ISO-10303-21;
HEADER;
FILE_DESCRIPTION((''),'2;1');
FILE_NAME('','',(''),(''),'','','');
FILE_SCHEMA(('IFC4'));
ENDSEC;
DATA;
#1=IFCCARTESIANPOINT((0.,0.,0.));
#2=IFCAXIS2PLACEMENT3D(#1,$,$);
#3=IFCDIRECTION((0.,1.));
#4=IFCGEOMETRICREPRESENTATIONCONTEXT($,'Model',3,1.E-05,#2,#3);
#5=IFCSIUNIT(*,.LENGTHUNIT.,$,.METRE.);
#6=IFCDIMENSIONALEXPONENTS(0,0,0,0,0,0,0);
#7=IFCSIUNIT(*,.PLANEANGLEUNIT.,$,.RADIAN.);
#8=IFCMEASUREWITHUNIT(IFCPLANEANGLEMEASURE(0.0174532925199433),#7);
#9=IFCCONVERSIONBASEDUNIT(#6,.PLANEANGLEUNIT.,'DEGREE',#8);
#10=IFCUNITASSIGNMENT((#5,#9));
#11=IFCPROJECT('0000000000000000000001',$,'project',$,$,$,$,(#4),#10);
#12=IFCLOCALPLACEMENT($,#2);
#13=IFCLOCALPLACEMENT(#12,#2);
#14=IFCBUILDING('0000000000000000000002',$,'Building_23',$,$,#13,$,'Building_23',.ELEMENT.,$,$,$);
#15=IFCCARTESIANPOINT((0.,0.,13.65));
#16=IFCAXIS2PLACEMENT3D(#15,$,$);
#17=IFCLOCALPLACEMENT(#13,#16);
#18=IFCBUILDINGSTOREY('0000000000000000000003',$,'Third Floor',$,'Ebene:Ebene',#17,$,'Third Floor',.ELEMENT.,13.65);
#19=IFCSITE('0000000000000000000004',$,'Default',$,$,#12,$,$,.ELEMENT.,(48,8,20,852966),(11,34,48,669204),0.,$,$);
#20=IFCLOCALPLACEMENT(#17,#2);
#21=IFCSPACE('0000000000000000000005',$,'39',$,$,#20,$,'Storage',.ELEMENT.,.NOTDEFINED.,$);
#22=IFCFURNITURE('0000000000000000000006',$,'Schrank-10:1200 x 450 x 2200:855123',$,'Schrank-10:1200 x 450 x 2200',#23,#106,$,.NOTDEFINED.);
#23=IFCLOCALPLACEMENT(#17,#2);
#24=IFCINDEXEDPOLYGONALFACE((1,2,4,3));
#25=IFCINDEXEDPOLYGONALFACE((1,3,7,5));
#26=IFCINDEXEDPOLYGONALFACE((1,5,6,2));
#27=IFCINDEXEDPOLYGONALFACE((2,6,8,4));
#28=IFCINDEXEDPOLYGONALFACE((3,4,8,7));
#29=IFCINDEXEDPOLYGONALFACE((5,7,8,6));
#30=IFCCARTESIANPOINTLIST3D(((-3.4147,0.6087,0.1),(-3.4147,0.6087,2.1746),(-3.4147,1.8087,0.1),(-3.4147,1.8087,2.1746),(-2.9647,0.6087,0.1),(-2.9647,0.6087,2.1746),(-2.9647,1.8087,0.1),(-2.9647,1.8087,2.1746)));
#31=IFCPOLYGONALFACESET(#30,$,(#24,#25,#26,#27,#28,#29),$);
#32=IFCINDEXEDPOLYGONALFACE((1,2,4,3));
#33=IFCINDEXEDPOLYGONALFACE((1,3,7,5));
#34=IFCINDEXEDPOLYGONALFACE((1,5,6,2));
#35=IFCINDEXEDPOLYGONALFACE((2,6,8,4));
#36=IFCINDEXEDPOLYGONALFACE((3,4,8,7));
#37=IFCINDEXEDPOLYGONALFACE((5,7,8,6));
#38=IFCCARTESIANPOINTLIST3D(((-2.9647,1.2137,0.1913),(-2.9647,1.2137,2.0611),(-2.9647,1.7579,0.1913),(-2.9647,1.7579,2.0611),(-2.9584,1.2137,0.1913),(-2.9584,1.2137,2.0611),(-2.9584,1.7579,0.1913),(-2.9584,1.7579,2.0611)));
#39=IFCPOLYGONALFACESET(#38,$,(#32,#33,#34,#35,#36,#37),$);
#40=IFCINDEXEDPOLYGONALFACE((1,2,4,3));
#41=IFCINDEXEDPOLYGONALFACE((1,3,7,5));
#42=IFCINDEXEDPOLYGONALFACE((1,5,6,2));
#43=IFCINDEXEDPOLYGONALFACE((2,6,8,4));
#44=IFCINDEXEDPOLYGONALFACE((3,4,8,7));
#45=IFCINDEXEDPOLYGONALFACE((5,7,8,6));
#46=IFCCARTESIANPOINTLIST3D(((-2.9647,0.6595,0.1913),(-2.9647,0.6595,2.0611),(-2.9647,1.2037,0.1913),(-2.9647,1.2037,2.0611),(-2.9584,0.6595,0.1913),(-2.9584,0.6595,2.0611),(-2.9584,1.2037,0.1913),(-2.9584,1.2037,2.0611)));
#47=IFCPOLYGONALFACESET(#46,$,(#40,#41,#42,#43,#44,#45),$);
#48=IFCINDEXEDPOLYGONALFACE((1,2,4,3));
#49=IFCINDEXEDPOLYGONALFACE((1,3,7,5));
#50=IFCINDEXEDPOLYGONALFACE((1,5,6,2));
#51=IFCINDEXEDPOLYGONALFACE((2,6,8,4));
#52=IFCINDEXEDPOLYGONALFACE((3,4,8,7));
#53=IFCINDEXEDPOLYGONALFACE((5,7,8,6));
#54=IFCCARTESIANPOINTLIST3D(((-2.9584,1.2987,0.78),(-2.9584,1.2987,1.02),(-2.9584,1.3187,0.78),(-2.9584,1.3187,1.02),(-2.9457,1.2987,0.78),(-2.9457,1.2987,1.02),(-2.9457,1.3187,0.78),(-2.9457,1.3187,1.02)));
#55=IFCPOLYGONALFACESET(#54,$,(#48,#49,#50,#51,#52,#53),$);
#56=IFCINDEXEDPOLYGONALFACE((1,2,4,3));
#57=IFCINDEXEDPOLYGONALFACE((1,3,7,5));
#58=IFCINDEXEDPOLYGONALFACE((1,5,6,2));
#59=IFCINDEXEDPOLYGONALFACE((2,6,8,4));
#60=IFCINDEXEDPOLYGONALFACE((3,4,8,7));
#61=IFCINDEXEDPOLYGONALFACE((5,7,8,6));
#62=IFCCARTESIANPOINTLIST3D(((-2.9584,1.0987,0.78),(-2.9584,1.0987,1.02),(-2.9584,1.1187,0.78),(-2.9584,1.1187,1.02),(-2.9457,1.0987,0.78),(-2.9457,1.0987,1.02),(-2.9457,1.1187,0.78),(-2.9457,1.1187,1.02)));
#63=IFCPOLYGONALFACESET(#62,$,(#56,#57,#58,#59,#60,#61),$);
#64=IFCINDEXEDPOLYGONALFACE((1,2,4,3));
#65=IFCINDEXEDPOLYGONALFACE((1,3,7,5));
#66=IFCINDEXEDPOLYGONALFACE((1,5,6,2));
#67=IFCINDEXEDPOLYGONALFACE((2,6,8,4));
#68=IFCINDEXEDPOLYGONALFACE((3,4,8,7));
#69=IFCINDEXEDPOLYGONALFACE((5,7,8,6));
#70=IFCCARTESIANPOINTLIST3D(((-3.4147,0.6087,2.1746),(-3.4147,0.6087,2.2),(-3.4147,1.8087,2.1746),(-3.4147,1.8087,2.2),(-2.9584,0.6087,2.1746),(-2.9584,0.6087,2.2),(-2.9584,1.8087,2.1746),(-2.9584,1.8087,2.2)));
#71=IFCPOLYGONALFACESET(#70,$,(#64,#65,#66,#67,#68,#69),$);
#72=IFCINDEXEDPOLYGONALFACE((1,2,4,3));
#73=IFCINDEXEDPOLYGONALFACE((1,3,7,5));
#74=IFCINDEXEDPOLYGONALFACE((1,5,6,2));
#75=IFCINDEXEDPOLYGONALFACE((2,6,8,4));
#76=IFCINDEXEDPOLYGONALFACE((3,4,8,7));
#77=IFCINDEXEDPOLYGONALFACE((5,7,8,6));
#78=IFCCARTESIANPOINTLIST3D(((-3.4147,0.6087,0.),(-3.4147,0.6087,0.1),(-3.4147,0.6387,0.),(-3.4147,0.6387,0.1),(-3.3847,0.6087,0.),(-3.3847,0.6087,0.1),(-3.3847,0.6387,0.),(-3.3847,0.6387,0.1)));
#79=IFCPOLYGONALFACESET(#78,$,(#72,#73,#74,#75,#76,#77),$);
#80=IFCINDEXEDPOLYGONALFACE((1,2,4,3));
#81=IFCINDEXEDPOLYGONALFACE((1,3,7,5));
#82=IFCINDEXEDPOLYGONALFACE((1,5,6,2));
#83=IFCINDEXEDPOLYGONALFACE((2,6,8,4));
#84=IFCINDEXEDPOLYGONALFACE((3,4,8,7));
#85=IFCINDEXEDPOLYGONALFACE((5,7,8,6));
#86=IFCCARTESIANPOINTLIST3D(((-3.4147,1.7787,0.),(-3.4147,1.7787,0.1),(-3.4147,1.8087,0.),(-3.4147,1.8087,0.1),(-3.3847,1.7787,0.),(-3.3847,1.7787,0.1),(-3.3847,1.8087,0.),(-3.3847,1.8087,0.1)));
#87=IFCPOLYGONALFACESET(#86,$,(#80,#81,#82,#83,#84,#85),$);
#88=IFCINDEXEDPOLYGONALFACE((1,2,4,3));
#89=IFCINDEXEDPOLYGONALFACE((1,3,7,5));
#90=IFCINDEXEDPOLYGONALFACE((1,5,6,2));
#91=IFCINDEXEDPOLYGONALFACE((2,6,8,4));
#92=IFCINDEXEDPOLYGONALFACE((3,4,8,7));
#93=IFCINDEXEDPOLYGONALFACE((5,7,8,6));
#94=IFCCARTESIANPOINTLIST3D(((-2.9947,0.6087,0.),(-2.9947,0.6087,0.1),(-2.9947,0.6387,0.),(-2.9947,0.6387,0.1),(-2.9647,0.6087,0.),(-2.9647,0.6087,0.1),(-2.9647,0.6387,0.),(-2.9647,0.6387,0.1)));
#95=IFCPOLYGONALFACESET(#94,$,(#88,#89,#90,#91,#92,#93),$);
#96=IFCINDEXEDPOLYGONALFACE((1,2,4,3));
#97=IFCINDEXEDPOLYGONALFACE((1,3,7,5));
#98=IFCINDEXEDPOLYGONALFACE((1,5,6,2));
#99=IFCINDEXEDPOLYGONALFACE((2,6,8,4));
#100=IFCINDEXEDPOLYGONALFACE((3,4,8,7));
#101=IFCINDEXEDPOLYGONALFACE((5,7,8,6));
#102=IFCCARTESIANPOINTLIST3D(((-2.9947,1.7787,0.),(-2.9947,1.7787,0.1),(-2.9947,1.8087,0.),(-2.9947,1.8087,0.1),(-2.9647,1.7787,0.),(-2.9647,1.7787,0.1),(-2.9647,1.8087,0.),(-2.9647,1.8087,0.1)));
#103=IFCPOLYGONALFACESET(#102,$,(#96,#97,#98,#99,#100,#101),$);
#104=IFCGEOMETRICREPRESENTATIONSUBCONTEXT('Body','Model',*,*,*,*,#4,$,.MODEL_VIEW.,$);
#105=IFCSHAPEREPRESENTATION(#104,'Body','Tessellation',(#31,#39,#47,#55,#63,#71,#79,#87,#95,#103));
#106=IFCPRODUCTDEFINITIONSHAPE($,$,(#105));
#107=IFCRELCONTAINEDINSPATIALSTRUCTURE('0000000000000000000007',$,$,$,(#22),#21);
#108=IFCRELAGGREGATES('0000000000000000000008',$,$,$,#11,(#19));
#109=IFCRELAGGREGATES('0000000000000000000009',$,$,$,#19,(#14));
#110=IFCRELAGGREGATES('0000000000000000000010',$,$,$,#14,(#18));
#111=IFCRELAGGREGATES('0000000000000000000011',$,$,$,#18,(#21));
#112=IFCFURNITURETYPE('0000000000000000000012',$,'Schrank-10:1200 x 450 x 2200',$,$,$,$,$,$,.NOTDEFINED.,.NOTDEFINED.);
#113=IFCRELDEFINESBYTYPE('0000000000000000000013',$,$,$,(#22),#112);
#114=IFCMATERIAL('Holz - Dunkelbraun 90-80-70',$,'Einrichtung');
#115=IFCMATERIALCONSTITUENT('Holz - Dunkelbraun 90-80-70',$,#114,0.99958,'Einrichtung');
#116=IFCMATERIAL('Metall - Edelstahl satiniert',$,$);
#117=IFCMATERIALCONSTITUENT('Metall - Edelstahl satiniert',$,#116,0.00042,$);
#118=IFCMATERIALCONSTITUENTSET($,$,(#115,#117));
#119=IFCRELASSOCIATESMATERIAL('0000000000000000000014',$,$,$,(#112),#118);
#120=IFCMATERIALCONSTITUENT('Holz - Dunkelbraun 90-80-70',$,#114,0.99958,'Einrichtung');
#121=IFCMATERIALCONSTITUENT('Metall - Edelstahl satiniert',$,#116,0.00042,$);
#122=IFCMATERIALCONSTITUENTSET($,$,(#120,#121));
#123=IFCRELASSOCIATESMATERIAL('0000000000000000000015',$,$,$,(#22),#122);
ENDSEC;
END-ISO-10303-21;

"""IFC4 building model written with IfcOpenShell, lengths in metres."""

from ifc_helpers import new_model, entity, si_unit, converted_unit, direction, frame, origin, place, context, subcontext, project, spatial, indexed_curve, outline, extrude, source, transform, mapped, material, constituent, constituent_set, type_object, type_shapes, element, save


model = new_model("IFC4")

# Units and contexts
model_context = context("Model", 3, precision=1e-05, world=origin(), true_north=direction((0.0, 1.0)))
body_context = subcontext(model_context, "Body", "Model", "MODEL_VIEW")
ifc_project = project(units=[si_unit("LENGTHUNIT", "METRE"), converted_unit("PLANEANGLEUNIT", "DEGREE", entity("IfcPlaneAngleMeasure", 0.0174532925199433), si_unit("PLANEANGLEUNIT", "RADIAN"), dimensions=[0, 0, 0, 0, 0, 0, 0])], contexts=[model_context])

# Site, building, storey
site_placement = place(None, origin())
site = spatial("IfcSite", under=ifc_project, at=site_placement, Name="Default", CompositionType="ELEMENT", RefLatitude=(48, 8, 20, 852966), RefLongitude=(11, 34, 48, 669204), RefElevation=0.0)
building_placement = place(site_placement, origin())
building = spatial("IfcBuilding", under=site, at=building_placement, Name="Building_23", LongName="Building_23", CompositionType="ELEMENT")
storey_placement = place(building_placement, frame((0.0, 0.0, 13.65)))
storey = spatial("IfcBuildingStorey", under=building, at=storey_placement, Name="Third Floor", ObjectType="Ebene:Ebene", LongName="Third Floor", CompositionType="ELEMENT", Elevation=13.65)

# Shared definitions
ifc_material_1 = material(Name="Holz - Dunkelbraun 90-80-70", Category="Einrichtung")
ifc_material_2 = material(Name="Metall - Edelstahl satiniert")

# Shared definitions
space_1_placement = place(storey_placement, origin())
space_1 = spatial("IfcSpace", under=storey, at=space_1_placement, Name="39", LongName="Storage", CompositionType="ELEMENT", PredefinedType="NOTDEFINED")

# Furniture
ifc_constituent_1 = constituent(ifc_material_1, Name="Holz - Dunkelbraun 90-80-70", Category="Einrichtung", fraction=0.99958)
ifc_constituent_2 = constituent(ifc_material_2, Name="Metall - Edelstahl satiniert", fraction=0.00042)
ifc_constituent_set_1 = constituent_set(constituents=[ifc_constituent_1, ifc_constituent_2])
furniture_type_1 = type_object("IfcFurnitureType", Name="Schrank-10:1200 x 450 x 2200", AssemblyPlace="NOTDEFINED", PredefinedType="NOTDEFINED", material=ifc_constituent_set_1)
shared_shape_1 = source(origin(), body_context, "Body", "SweptSolid", [
    extrude(outline(indexed_curve([(-0.225, -0.6), (0.225, -0.6), (0.225, 0.6), (-0.225, 0.6), (-0.225, -0.6)], self_intersect=False)), frame((-0.2692, -0.3632, 0.1), z_axis=(0.0, 0.0, 1.0), x_axis=(0.0, 1.0, 0.0)), (0.0, 0.0, 1.0), 2.0746),
    extrude(outline(indexed_curve([(-0.0032, -0.2721), (0.0032, -0.2721), (0.0032, 0.2721), (-0.0032, 0.2721), (-0.0032, -0.2721)], self_intersect=False)), frame((0.0079, -0.5913, 0.1913), z_axis=(0.0, 0.0, 1.0), x_axis=(0.0, 1.0, 0.0)), (0.0, 0.0, 1.0), 1.8698),
    extrude(outline(indexed_curve([(-0.0032, -0.2721), (0.0032, -0.2721), (0.0032, 0.2721), (-0.0032, 0.2721), (-0.0032, -0.2721)], self_intersect=False)), frame((-0.5463, -0.5913, 0.1913), z_axis=(0.0, 0.0, 1.0), x_axis=(0.0, 1.0, 0.0)), (0.0, 0.0, 1.0), 1.8698),
    extrude(outline(indexed_curve([(-0.0063, -0.01), (0.0063, -0.01), (0.0063, 0.01), (-0.0063, 0.01), (-0.0063, -0.01)], self_intersect=False)), frame((-0.1692, -0.6009, 0.78), z_axis=(0.0, 0.0, 1.0), x_axis=(0.0, 1.0, 0.0)), (0.0, 0.0, 1.0), 0.24),
    extrude(outline(indexed_curve([(-0.0063, -0.01), (0.0063, -0.01), (0.0063, 0.01), (-0.0063, 0.01), (-0.0063, -0.01)], self_intersect=False)), frame((-0.3692, -0.6009, 0.78), z_axis=(0.0, 0.0, 1.0), x_axis=(0.0, 1.0, 0.0)), (0.0, 0.0, 1.0), 0.24),
    extrude(outline(indexed_curve([(-0.6, -0.2282), (0.6, -0.2282), (0.6, 0.2282), (-0.6, 0.2282), (-0.6, -0.2282)], self_intersect=False)), frame((-0.2692, -0.3663, 2.1746), z_axis=(0.0, 0.0, 1.0), x_axis=(-1.0, 0.0, 0.0)), (0.0, 0.0, 1.0), 0.0254),
    extrude(outline(indexed_curve([(-0.015, -0.015), (0.015, -0.015), (0.015, 0.015), (-0.015, 0.015), (-0.015, -0.015)], self_intersect=False)), frame((-0.8542, -0.1532, 0.0), z_axis=(0.0, 0.0, 1.0), x_axis=(-1.0, 0.0, 0.0)), (0.0, 0.0, 1.0), 0.1),
    extrude(outline(indexed_curve([(-0.015, -0.015), (0.015, -0.015), (0.015, 0.015), (-0.015, 0.015), (-0.015, -0.015)], self_intersect=False)), frame((0.3158, -0.1532, 0.0), z_axis=(0.0, 0.0, 1.0), x_axis=(0.0, -1.0, 0.0)), (0.0, 0.0, 1.0), 0.1),
    extrude(outline(indexed_curve([(-0.015, -0.015), (0.015, -0.015), (0.015, 0.015), (-0.015, 0.015), (-0.015, -0.015)], self_intersect=False)), frame((-0.8542, -0.5732, 0.0), z_axis=(0.0, 0.0, 1.0), x_axis=(0.0, 1.0, 0.0)), (0.0, 0.0, 1.0), 0.1),
    extrude(outline(indexed_curve([(-0.015, -0.015), (0.015, -0.015), (0.015, 0.015), (-0.015, 0.015), (-0.015, -0.015)], self_intersect=False)), frame((0.3158, -0.5732, 0.0)), (0.0, 0.0, 1.0), 0.1),
])
type_shapes(furniture_type_1, [shared_shape_1])
ifc_constituent_3 = constituent(ifc_material_1, Name="Holz - Dunkelbraun 90-80-70", Category="Einrichtung", fraction=0.99958)
ifc_constituent_4 = constituent(ifc_material_2, Name="Metall - Edelstahl satiniert", fraction=0.00042)
ifc_constituent_set_2 = constituent_set(constituents=[ifc_constituent_3, ifc_constituent_4])
furniture_1_placement = place(space_1_placement, frame((-3.5529, 1.4779, 0.0), z_axis=(0.0, 0.0, 1.0), x_axis=(0.0, 1.0, 0.0)))
element("IfcFurniture", 1, at=furniture_1_placement, inside=space_1, type_object=furniture_type_1, material=ifc_constituent_set_2, Name="Schrank-10:1200 x 450 x 2200:855123", ObjectType="Schrank-10:1200 x 450 x 2200", PredefinedType="NOTDEFINED", context=body_context, shape_type="MappedRepresentation", body=[
    mapped(shared_shape_1, transform((0.0, 0.0, 0.0), scale=1.0)),
])

save(model, "model.ifc")
